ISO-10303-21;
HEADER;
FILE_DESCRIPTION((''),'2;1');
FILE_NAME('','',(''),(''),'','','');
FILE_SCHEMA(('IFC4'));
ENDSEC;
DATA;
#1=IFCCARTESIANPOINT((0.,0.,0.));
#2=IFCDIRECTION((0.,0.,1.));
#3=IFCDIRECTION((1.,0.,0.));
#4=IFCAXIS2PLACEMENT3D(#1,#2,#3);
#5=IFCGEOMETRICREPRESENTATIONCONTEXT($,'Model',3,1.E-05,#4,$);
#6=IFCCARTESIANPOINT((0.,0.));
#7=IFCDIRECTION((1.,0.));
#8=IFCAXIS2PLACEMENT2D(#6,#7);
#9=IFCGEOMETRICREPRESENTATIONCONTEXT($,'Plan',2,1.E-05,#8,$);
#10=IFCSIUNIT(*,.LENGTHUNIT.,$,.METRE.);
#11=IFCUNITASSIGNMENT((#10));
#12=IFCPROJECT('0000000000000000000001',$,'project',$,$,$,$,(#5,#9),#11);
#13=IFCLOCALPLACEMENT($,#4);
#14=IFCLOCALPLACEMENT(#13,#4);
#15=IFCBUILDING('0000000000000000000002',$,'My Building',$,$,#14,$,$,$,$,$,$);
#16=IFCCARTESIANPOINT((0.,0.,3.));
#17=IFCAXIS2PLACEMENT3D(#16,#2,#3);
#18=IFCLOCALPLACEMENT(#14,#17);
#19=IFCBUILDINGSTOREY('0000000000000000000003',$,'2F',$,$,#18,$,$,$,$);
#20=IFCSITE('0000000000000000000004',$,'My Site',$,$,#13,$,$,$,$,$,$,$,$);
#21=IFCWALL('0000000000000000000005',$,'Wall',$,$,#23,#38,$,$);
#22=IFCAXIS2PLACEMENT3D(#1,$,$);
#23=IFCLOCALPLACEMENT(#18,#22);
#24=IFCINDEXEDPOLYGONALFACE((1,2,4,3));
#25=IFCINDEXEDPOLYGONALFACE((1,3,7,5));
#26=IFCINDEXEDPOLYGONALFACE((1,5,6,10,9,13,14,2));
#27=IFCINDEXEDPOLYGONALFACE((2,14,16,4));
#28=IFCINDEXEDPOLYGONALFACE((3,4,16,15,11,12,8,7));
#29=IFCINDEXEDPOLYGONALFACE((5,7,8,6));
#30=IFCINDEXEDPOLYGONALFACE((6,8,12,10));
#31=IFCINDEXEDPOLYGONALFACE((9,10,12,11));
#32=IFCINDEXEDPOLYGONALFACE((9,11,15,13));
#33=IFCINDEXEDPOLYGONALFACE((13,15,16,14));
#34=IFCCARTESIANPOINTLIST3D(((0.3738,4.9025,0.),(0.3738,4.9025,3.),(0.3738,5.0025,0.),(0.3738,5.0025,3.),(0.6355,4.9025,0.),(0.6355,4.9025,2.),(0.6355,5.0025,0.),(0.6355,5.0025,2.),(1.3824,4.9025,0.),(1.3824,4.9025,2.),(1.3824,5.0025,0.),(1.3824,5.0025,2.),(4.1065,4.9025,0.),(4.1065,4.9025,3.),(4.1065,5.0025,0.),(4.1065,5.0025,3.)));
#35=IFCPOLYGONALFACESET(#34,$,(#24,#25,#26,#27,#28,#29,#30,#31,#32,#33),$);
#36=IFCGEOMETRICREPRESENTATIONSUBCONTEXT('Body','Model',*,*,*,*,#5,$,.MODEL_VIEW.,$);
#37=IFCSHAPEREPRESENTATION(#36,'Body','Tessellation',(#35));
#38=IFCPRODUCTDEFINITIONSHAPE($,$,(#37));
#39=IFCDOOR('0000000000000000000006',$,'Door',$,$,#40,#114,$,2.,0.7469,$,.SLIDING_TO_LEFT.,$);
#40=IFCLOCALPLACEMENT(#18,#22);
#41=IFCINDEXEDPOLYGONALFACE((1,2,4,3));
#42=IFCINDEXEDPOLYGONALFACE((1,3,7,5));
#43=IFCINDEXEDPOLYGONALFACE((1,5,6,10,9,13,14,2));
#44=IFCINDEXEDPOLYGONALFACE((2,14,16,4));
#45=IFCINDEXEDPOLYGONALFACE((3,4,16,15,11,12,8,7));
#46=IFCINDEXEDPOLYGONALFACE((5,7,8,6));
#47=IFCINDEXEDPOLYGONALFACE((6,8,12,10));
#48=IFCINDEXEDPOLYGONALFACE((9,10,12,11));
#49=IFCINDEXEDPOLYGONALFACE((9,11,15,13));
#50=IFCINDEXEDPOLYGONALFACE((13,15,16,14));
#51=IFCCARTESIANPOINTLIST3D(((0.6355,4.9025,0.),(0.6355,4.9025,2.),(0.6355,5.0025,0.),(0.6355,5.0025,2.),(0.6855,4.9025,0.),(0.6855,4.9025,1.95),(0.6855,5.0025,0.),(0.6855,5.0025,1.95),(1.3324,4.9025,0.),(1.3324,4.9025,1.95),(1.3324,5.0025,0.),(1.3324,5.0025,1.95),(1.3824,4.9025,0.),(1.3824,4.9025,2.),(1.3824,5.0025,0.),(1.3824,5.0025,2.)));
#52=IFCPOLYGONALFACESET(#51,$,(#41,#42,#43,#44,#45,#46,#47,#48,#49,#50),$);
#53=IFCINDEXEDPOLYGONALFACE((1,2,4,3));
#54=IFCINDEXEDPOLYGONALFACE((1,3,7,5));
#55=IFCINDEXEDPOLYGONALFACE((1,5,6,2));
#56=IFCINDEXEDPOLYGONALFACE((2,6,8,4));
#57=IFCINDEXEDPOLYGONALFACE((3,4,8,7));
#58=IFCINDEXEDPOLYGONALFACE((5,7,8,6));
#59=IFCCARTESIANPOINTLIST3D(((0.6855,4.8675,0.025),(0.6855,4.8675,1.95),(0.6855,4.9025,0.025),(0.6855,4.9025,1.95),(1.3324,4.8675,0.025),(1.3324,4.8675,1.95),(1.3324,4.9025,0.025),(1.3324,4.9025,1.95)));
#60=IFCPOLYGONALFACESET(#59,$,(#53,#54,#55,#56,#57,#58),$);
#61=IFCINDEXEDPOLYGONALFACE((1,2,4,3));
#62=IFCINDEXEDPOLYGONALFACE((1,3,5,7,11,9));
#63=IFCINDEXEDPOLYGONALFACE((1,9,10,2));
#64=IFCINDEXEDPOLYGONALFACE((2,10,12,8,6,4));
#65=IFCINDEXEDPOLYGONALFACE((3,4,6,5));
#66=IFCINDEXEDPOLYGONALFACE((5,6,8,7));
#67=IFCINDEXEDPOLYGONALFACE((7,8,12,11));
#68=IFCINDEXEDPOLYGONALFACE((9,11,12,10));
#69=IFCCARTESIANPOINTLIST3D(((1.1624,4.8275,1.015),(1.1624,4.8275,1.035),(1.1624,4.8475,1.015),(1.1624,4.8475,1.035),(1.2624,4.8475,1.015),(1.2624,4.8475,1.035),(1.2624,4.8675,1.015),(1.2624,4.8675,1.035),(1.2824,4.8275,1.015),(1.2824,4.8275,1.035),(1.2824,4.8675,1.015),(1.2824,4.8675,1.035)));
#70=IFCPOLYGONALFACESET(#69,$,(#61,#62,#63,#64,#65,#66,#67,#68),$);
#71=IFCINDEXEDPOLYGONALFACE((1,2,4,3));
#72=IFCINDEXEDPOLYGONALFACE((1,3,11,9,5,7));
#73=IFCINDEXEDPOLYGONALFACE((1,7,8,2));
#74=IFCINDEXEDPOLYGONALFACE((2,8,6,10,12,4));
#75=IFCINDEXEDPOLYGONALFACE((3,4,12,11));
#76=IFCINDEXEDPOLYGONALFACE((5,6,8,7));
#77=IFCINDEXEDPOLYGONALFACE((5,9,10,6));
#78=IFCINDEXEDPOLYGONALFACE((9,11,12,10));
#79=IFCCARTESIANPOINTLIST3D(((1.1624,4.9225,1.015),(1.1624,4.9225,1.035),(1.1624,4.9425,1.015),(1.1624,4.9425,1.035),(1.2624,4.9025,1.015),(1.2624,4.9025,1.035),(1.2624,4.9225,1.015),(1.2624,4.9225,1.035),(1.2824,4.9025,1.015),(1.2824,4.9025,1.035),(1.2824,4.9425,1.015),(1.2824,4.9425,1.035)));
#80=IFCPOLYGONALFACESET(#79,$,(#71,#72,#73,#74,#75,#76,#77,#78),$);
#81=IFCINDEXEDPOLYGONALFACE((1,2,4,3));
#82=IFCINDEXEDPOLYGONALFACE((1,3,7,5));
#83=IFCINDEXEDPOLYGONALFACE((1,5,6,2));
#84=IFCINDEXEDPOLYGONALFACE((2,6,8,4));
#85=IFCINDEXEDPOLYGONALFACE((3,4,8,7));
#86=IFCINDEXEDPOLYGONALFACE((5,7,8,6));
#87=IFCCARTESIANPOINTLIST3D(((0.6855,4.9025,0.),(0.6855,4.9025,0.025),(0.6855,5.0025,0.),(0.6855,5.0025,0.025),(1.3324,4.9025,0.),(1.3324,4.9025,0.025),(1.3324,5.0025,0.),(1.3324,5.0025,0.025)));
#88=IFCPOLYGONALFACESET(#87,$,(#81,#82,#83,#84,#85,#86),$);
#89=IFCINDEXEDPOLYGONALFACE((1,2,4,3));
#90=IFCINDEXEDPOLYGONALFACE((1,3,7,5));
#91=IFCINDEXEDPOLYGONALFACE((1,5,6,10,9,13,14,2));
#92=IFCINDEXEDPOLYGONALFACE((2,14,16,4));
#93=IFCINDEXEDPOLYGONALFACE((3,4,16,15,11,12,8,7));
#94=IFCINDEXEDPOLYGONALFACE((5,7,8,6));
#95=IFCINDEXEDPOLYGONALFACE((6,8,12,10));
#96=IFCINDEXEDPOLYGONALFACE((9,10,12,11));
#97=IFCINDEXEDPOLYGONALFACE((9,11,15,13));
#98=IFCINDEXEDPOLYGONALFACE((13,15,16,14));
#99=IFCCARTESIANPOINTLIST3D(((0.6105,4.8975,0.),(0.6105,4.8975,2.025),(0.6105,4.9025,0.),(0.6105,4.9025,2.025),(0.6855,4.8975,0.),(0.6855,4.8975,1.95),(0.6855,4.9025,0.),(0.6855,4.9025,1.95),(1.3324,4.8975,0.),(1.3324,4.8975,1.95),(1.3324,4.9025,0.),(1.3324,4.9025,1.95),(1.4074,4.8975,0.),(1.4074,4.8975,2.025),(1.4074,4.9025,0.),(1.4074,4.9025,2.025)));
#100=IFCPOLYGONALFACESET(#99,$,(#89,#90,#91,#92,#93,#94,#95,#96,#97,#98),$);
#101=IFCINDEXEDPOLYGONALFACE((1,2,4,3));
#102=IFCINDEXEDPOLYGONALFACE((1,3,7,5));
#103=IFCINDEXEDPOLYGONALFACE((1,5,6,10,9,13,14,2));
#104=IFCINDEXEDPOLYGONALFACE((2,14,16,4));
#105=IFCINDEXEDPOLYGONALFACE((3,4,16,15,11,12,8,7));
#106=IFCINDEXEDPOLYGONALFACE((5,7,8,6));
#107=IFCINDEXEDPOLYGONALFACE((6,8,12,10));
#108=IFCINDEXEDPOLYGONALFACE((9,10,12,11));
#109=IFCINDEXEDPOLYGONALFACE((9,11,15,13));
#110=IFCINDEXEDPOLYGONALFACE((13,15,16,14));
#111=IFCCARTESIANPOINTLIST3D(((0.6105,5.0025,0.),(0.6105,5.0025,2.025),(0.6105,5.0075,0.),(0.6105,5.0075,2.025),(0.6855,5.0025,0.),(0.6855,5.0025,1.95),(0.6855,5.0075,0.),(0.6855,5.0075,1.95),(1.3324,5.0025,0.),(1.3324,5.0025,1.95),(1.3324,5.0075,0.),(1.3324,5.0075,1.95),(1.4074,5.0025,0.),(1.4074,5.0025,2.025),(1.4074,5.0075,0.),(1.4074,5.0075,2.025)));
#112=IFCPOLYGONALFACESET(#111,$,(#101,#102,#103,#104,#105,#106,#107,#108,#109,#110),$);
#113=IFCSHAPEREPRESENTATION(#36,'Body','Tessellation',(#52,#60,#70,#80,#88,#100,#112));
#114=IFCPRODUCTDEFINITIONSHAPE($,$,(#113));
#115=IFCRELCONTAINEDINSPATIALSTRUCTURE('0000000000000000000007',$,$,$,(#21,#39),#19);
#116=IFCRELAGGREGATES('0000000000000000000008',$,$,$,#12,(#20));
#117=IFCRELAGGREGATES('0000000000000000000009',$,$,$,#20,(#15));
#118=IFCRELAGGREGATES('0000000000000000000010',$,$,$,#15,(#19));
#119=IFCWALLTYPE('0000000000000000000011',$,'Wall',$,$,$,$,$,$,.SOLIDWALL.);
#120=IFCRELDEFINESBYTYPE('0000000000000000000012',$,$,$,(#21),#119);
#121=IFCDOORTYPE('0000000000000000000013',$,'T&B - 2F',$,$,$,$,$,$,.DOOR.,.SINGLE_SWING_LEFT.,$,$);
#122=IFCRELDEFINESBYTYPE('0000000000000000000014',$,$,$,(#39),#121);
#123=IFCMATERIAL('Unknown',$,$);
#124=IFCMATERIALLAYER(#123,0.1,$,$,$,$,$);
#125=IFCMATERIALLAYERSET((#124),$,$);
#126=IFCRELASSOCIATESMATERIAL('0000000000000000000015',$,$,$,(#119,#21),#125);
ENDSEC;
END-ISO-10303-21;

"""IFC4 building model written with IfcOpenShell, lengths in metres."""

from ifc_helpers import new_model, entity, si_unit, frame, origin_with_axes, origin_2d_with_axis, place, context, subcontext, project, spatial, line, indexed_curve, outline, extrude, shape, source, transform, mapped, material, layer, layer_set, layer_usage, type_object, type_shapes, element, fill, save


model = new_model("IFC4")

# Units and contexts
model_context = context("Model", 3, precision=1e-05, world=origin_with_axes())
plan_context = context("Plan", 2, precision=1e-05, world=origin_2d_with_axis())
body_context_1 = subcontext(model_context, "Body", "Model", "MODEL_VIEW")
body_context_2 = subcontext(plan_context, "Body", "Plan", "PLAN_VIEW")
ifc_project = project(units=[si_unit("LENGTHUNIT", "METRE")], contexts=[model_context, plan_context])

# Site, building, storey
site_placement = place(None, origin_with_axes())
site = spatial("IfcSite", under=ifc_project, at=site_placement, Name="My Site")
building_placement = place(site_placement, origin_with_axes())
building = spatial("IfcBuilding", under=site, at=building_placement, Name="My Building")
storey_placement = place(building_placement, frame((0.0, 0.0, 3.0), z_axis=(0.0, 0.0, 1.0), x_axis=(1.0, 0.0, 0.0)))
storey = spatial("IfcBuildingStorey", under=building, at=storey_placement, Name="2F")

# Shared definitions
ifc_material = material(Name="Unknown")

# Shared definitions
ifc_layer_1 = layer(ifc_material, 0.1)
ifc_layer_set_1 = layer_set([ifc_layer_1])
wall_type = type_object("IfcWallType", Name="Wall", PredefinedType="SOLIDWALL", material=ifc_layer_set_1)

# Wall, opening, door
ifc_layer_usage_1 = layer_usage(ifc_layer_set_1, "AXIS2", "POSITIVE", 0.0)
wall_1_placement = place(storey_placement, frame((4.1065, 5.0025, 0.0), z_axis=(0.0, 0.0, 1.0), x_axis=(-1.0, 0.0, 0.0)))
wall_1 = element("IfcWall", 1, at=wall_1_placement, inside=storey, type_object=wall_type, material=ifc_layer_usage_1, Name="Wall", context=body_context_1, shape_type="SweptSolid", body=[
    extrude(outline(indexed_curve([(0.0, 0.0), (0.0, 0.1), (3.7327, 0.1), (3.7327, 0.0)], segments=[line(1, 2, 3, 4, 1)])), origin_with_axes(), (0.0, 0.0, 1.0), 3.0),
])
shared_shape_1 = source(origin_with_axes(), body_context_1, "Body", "SweptSolid", [
    extrude(outline(indexed_curve([(0.0, 0.0), (0.7469, 0.0), (0.7469, 2.0), (0.0, 2.0)], segments=[line(1, 2, 3, 4, 1)])), frame((0.0, -0.6, 0.0), z_axis=(0.0, -1.0, 0.0), x_axis=(1.0, 0.0, 0.0)), (0.0, 0.0, -1.0), 1.2),
])
opening_1_placement = place(wall_1_placement, frame((3.471, 0.1, 0.0), z_axis=(0.0, 0.0, 1.0), x_axis=(-1.0, 0.000001, 0.0)))
opening_1 = element("IfcOpeningElement", 2, at=opening_1_placement, cuts=wall_1, PredefinedType="OPENING", context=body_context_1, shape_type="MappedRepresentation", body=[
    mapped(shared_shape_1, transform((0.0, 0.0, 0.0), x_axis=(1.0, 0.0, 0.0), y_axis=(0.0, 1.0, 0.0), z_axis=(0.0, 0.0, 1.0), scale=1.0)),
])
door_type_1 = type_object("IfcDoorType", Name="T&B - 2F", OperationType="SINGLE_SWING_LEFT", PredefinedType="DOOR")
shared_shape_2 = source(origin_with_axes(), body_context_1, "Body", "SweptSolid", [
    extrude(outline(indexed_curve([(0.0, 0.0), (0.0, 2.0), (0.7469, 2.0), (0.7469, 0.0), (0.6969, 0.0), (0.6969, 1.95), (0.05, 1.95), (0.05, 0.0)], segments=[line(1, 2, 3, 4, 5, 6, 7, 8, 1)])), frame((0.0, 0.0, 0.0), z_axis=(0.0, -1.0, 0.0), x_axis=(1.0, 0.0, 0.0)), (0.0, 0.0, -1.0), 0.1),
    extrude(outline(indexed_curve([(0.0, 0.0), (0.6469, 0.0), (0.6469, 0.035), (0.0, 0.035)], segments=[line(1, 2, 3, 4, 1)])), frame((0.05, -0.035, 0.025), z_axis=(0.0, 0.0, 1.0), x_axis=(1.0, 0.0, 0.0)), (0.0, 0.0, 1.0), 1.925),
    extrude(outline(indexed_curve([(0.0, 0.0), (0.0, -0.04), (-0.12, -0.04), (-0.12, -0.02), (-0.02, -0.02), (-0.02, 0.0)], segments=[line(1, 2, 3, 4, 5, 6, 1)])), frame((0.6469, -0.035, 1.015), z_axis=(0.0, 0.0, 1.0), x_axis=(1.0, 0.0, 0.0)), (0.0, 0.0, 1.0), 0.02),
    extrude(outline(indexed_curve([(0.0, 0.0), (0.0, 0.04), (-0.12, 0.04), (-0.12, 0.02), (-0.02, 0.02), (-0.02, 0.0)], segments=[line(1, 2, 3, 4, 5, 6, 1)])), frame((0.6469, 0.0, 1.015), z_axis=(0.0, 0.0, 1.0), x_axis=(1.0, 0.0, 0.0)), (0.0, 0.0, 1.0), 0.02),
    extrude(outline(indexed_curve([(0.0, 0.0), (0.6469, 0.0), (0.6469, 0.1), (0.0, 0.1)], segments=[line(1, 2, 3, 4, 1)])), frame((0.05, 0.0, 0.0), z_axis=(0.0, 0.0, 1.0), x_axis=(1.0, 0.0, 0.0)), (0.0, 0.0, 1.0), 0.025),
    extrude(outline(indexed_curve([(0.0, 0.0), (0.0, 2.025), (0.7969, 2.025), (0.7969, 0.0), (0.7219, 0.0), (0.7219, 1.95), (0.075, 1.95), (0.075, 0.0)], segments=[line(1, 2, 3, 4, 5, 6, 7, 8, 1)])), frame((-0.025, -0.005, 0.0), z_axis=(0.0, -1.0, 0.0), x_axis=(1.0, 0.0, 0.0)), (0.0, 0.0, -1.0), 0.005),
    extrude(outline(indexed_curve([(0.0, 0.0), (0.0, 2.025), (0.7969, 2.025), (0.7969, 0.0), (0.7219, 0.0), (0.7219, 1.95), (0.075, 1.95), (0.075, 0.0)], segments=[line(1, 2, 3, 4, 5, 6, 7, 8, 1)])), frame((-0.025, 0.1, 0.0), z_axis=(0.0, -1.0, 0.0), x_axis=(1.0, 0.0, 0.0)), (0.0, 0.0, -1.0), 0.005),
])
shared_shape_3 = source(origin_with_axes(), body_context_2, "Body", "Curve2D", [
    entity("IfcIndexedPolyCurve", entity("IfcCartesianPointList2D", [[0.0, 0.0], [0.05, 0.0], [0.05, 0.1], [0.0, 0.1]]), [entity("IfcLineIndex", [1, 2, 3, 4, 1])]),
    entity("IfcIndexedPolyCurve", entity("IfcCartesianPointList2D", [[0.7469, 0.0], [0.6969, 0.0], [0.6969, 0.1], [0.7469, 0.1]]), [entity("IfcLineIndex", [1, 2, 3, 4, 1])]),
    entity("IfcIndexedPolyCurve", entity("IfcCartesianPointList2D", [[-0.2734, -0.035], [0.3734, -0.035], [0.3734, 0.0], [-0.2734, 0.0]]), [entity("IfcLineIndex", [1, 2, 3, 4, 1])]),
])
type_shapes(door_type_1, [shared_shape_2, shared_shape_3])
door_1_placement = place(opening_1_placement, frame((0.0, 0.0, 0.0), z_axis=(0.0, 0.0, 1.0), x_axis=(1.0, 0.0, 0.0)))
door_1 = element("IfcDoor", 3, at=door_1_placement, inside=storey, type_object=door_type_1, Name="Door", OperationType="SLIDING_TO_LEFT", OverallHeight=2.0, OverallWidth=0.7469, shapes=[
    shape(body_context_1, "Body", "MappedRepresentation", [mapped(shared_shape_2, transform((0.0, 0.0, 0.0), x_axis=(1.0, 0.0, 0.0), y_axis=(0.0, 1.0, 0.0), z_axis=(0.0, 0.0, 1.0), scale=1.0))]),
    shape(body_context_2, "Body", "MappedRepresentation", [mapped(shared_shape_3, transform((0.0, 0.0, 0.0), x_axis=(1.0, 0.0, 0.0), y_axis=(0.0, 1.0, 0.0), z_axis=(0.0, 0.0, 1.0), scale=1.0))]),
])
fill(opening_1, door_1)

save(model, "model.ifc")
